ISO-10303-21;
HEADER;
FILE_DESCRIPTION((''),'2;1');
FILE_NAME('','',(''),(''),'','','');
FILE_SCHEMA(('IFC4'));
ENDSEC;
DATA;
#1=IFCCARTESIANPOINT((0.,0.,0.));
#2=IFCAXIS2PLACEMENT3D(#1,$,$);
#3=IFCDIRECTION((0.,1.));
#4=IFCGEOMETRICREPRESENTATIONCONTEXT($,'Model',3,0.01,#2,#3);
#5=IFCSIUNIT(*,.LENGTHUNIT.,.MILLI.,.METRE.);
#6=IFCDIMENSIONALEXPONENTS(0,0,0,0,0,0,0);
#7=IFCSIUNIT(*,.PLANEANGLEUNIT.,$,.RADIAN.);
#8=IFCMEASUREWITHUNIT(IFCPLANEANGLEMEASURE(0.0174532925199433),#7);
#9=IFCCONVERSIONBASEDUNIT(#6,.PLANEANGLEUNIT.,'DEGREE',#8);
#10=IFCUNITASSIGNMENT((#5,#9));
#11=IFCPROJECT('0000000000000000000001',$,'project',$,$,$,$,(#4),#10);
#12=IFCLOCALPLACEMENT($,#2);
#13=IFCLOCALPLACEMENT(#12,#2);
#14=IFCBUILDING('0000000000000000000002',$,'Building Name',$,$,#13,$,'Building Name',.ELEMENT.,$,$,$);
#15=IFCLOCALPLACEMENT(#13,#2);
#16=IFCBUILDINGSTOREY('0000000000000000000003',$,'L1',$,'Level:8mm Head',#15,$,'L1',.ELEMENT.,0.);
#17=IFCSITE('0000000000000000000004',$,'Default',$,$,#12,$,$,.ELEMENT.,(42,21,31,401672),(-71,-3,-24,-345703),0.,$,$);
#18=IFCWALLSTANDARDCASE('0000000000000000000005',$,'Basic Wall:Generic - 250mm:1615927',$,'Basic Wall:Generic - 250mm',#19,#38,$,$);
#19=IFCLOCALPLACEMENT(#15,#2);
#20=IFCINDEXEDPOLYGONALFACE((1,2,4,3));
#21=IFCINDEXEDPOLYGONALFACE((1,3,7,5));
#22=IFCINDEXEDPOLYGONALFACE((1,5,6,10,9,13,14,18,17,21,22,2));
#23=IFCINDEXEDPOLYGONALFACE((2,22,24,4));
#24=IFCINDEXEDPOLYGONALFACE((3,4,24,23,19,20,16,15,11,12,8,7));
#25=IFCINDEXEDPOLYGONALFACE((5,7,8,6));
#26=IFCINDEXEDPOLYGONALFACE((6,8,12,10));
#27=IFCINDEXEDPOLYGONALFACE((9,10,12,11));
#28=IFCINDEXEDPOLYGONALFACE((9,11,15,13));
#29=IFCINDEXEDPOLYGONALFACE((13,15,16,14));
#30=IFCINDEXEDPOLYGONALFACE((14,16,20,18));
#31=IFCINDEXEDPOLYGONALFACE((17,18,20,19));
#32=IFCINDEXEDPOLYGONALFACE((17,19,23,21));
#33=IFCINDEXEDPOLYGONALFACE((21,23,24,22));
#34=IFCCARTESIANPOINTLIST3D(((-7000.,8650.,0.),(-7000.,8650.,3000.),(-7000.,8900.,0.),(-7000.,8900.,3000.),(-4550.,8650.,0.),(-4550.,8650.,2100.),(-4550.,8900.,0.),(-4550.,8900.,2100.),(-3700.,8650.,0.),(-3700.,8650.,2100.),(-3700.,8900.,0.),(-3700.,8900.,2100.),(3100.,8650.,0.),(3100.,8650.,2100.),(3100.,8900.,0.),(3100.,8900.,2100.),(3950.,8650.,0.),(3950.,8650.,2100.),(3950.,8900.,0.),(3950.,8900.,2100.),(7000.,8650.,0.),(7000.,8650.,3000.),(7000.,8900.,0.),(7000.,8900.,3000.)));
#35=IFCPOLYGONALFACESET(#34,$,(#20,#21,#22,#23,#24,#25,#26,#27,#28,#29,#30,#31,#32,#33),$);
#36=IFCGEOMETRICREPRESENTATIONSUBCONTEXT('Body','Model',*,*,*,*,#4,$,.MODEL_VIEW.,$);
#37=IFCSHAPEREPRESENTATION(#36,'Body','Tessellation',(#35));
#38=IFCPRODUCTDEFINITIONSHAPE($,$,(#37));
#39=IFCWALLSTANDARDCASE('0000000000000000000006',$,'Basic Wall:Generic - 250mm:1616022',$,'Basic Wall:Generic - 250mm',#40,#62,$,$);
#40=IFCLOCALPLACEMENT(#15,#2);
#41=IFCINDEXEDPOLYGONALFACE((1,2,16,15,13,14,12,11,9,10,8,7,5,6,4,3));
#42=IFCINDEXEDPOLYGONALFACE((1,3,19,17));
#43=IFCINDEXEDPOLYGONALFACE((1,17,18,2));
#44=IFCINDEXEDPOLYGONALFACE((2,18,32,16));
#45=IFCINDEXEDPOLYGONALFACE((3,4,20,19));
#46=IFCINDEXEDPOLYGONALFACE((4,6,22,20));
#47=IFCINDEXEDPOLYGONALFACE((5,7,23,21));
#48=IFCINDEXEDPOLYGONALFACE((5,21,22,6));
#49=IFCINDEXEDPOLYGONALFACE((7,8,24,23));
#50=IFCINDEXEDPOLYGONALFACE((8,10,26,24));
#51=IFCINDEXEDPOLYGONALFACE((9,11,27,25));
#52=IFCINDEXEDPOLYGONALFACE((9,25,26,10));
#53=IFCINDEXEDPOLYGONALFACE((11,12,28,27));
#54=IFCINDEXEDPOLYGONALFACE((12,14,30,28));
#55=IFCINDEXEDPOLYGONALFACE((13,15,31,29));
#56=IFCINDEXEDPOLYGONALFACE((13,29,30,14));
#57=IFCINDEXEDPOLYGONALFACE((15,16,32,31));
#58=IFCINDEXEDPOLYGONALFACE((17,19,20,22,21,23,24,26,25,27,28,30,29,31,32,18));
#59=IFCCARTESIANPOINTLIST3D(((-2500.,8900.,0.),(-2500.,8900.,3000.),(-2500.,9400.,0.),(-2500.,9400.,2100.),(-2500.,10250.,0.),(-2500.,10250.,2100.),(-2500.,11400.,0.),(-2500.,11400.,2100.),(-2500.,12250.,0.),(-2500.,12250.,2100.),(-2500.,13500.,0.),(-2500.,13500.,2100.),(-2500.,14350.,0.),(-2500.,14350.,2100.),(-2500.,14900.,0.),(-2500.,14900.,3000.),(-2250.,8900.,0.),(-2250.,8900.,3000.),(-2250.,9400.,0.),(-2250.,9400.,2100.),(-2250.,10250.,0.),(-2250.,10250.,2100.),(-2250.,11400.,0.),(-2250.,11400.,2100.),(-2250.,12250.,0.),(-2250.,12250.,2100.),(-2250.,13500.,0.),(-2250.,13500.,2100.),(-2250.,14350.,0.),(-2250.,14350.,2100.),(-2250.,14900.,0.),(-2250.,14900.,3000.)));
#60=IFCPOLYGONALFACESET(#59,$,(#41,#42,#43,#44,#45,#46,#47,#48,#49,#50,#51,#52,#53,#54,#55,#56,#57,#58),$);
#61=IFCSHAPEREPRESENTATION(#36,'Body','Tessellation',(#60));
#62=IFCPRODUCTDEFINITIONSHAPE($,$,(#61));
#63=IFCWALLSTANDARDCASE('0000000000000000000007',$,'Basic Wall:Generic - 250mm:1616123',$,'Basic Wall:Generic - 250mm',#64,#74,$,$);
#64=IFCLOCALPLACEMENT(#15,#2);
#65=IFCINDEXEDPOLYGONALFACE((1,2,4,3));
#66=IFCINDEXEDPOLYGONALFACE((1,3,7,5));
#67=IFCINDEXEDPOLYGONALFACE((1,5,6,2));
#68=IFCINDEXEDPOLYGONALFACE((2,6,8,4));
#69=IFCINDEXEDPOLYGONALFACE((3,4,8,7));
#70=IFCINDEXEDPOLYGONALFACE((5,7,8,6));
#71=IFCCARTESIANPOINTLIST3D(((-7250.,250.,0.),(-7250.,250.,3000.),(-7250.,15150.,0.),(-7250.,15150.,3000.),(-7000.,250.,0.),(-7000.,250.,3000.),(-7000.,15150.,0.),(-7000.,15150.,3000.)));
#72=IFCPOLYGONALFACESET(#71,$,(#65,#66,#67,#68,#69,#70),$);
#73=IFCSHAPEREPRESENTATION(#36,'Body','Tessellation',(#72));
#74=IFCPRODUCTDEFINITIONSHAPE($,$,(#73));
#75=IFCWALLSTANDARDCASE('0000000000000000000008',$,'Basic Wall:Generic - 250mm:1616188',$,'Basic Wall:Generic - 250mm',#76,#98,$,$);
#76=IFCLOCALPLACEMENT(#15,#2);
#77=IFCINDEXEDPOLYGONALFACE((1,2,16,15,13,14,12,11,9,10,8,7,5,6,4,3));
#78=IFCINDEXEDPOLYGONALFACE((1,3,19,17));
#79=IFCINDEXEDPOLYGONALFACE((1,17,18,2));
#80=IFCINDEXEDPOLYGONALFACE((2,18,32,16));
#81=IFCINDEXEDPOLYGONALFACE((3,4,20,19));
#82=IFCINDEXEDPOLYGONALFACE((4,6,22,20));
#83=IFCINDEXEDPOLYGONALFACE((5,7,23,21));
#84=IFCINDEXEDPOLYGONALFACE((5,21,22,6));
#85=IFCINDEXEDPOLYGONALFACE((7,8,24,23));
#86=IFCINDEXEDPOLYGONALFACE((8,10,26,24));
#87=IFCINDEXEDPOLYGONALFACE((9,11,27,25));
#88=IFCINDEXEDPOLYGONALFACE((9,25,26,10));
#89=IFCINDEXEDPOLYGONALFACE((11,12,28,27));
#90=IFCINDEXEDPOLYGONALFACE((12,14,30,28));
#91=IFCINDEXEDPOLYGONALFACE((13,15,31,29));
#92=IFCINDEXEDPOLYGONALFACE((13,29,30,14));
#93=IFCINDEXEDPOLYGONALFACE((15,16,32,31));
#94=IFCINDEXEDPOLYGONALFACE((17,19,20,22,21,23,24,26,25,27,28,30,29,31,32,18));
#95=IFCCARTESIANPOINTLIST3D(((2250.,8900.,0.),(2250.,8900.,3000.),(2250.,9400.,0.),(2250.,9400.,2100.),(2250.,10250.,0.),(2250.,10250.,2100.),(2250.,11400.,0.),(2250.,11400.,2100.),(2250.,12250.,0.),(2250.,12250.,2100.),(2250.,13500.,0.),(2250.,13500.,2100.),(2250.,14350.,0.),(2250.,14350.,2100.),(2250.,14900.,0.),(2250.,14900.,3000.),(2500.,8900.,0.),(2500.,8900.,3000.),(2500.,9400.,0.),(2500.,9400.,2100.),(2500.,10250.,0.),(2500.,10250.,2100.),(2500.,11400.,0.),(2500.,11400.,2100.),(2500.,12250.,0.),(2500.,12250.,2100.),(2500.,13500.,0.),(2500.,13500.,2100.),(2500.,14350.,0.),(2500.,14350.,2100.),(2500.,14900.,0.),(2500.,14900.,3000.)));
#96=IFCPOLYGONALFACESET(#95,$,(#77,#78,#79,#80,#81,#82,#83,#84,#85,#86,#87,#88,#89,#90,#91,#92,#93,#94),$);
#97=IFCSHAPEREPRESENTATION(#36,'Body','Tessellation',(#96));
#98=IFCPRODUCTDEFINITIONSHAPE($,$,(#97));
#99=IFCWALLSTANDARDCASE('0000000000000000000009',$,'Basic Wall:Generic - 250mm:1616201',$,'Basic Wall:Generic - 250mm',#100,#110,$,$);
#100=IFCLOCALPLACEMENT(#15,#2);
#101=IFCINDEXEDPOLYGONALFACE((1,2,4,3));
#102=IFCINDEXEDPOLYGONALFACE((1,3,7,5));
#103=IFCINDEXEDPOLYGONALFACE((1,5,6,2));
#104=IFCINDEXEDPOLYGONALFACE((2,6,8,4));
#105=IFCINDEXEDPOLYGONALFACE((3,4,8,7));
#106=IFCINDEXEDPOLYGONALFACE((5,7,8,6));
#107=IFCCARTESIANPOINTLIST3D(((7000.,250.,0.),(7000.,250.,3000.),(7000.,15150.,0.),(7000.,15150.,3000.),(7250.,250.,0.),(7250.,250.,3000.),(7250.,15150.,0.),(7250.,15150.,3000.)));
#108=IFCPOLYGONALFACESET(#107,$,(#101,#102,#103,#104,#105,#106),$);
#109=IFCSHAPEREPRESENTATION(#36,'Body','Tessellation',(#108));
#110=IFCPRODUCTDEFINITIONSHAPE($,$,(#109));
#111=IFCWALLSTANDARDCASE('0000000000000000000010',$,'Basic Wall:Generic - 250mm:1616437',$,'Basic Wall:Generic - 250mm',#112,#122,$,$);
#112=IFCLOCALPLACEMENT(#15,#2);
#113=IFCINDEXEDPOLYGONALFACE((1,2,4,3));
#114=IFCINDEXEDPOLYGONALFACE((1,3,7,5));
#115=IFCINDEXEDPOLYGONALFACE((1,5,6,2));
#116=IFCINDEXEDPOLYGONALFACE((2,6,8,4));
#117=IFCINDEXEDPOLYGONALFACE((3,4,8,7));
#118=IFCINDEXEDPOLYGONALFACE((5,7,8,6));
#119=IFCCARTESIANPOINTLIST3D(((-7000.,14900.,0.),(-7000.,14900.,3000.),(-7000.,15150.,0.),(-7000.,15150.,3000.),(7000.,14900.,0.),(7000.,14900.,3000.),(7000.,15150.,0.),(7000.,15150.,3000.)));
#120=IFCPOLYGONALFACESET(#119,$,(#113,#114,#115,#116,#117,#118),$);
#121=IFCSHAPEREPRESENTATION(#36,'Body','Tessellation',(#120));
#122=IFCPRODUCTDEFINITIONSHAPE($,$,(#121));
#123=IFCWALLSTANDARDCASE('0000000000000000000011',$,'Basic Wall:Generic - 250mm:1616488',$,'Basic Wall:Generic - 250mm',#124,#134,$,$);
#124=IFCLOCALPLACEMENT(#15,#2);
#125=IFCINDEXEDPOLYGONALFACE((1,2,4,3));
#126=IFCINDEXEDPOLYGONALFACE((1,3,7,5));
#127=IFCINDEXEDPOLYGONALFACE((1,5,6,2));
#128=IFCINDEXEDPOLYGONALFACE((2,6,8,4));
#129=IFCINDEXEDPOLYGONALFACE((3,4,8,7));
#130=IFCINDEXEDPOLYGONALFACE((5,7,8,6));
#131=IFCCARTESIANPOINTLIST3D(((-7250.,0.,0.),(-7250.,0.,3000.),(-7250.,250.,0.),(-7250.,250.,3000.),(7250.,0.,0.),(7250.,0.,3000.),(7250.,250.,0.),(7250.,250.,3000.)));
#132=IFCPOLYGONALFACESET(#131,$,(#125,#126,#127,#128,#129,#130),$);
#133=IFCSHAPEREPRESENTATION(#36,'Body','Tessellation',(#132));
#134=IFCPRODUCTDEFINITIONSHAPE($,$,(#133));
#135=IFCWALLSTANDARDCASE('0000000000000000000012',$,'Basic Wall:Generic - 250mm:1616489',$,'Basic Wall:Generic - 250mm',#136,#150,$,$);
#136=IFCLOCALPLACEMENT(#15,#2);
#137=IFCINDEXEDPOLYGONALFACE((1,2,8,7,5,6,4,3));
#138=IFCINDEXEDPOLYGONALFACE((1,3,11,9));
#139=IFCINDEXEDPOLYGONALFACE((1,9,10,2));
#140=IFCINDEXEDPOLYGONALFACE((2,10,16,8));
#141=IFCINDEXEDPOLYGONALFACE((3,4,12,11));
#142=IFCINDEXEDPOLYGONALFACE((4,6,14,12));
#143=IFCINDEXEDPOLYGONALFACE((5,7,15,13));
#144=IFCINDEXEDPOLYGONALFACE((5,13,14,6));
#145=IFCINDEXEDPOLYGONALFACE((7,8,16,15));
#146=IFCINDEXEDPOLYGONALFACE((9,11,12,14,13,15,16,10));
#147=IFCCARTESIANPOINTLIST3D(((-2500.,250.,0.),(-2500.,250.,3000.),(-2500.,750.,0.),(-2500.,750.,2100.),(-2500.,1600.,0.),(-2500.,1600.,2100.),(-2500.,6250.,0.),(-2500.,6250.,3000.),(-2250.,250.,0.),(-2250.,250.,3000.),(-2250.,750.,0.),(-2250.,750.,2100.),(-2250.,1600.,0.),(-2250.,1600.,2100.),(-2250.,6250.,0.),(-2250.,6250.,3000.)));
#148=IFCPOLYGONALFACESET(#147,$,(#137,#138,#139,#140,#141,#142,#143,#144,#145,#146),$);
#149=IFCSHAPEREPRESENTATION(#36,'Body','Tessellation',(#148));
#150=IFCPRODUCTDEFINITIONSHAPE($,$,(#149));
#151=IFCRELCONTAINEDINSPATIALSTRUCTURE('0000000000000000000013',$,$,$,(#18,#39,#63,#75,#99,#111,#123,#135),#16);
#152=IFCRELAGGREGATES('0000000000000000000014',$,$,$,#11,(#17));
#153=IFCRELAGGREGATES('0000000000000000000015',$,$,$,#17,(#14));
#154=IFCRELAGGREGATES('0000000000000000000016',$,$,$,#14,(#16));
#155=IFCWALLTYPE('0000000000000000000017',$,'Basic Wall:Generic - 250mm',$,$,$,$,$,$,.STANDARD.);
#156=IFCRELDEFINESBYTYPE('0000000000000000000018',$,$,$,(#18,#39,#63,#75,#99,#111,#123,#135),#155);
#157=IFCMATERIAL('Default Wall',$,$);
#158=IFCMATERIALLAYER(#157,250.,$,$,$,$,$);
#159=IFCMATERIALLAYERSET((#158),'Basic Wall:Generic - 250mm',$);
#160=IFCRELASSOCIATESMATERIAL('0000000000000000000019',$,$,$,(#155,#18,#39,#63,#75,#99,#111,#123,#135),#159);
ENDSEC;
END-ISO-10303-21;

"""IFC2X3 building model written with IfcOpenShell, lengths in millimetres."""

from ifc_helpers import new_model, entity, si_unit, converted_unit, direction, frame, frame_2d, origin, place, context, subcontext, project, spatial, rectangle, extrude, material, layer, layer_set, layer_usage, type_object, element, save


model = new_model("IFC2X3")

# Units and contexts
model_context = context("Model", 3, precision=0.01, world=origin(), true_north=direction((0.0, 1.0)))
body_context = subcontext(model_context, "Body", "Model", "MODEL_VIEW")
ifc_project = project(units=[si_unit("LENGTHUNIT", "METRE", prefix="MILLI"), converted_unit("PLANEANGLEUNIT", "DEGREE", entity("IfcPlaneAngleMeasure", 0.0174532925199433), si_unit("PLANEANGLEUNIT", "RADIAN"), dimensions=[0, 0, 0, 0, 0, 0, 0])], contexts=[model_context])

# Site, building, storey
site_placement = place(None, origin())
site = spatial("IfcSite", under=ifc_project, at=site_placement, Name="Default", CompositionType="ELEMENT", RefLatitude=(42, 21, 31, 401672), RefLongitude=(-71, -3, -24, -345703), RefElevation=0.0)
building_placement = place(site_placement, origin())
building = spatial("IfcBuilding", under=site, at=building_placement, Name="Building Name", LongName="Building Name", CompositionType="ELEMENT")
storey_placement = place(building_placement, origin())
storey = spatial("IfcBuildingStorey", under=building, at=storey_placement, Name="L1", ObjectType="Level:8mm Head", LongName="L1", CompositionType="ELEMENT", Elevation=0.0)

# Walls, openings
ifc_material = material(Name="Default Wall")
ifc_layer_1 = layer(ifc_material, 250.0)
ifc_layer_set_1 = layer_set([ifc_layer_1], Name="Basic Wall:Generic - 250mm")
ifc_layer_usage_1 = layer_usage(ifc_layer_set_1, "AXIS2", "NEGATIVE", 125.0)
wall_type_1 = type_object("IfcWallType", Name="Basic Wall:Generic - 250mm", PredefinedType="STANDARD", material=ifc_layer_set_1)
wall_1_placement = place(storey_placement, frame((-7000.0, 8775.0, 0.0)))
wall_1 = element("IfcWallStandardCase", 1, at=wall_1_placement, inside=storey, type_object=wall_type_1, material=ifc_layer_usage_1, Name="Basic Wall:Generic - 250mm:1615927", ObjectType="Basic Wall:Generic - 250mm", context=body_context, shape_type="SweptSolid", body=[
    extrude(rectangle(XDim=14000.0, YDim=250.0, at=frame_2d((7000.0, 0.0), x_axis=(1.0, 0.0))), origin(), (0.0, 0.0, 1.0), 3000.0),
])
opening_1_placement = place(wall_1_placement, frame((2450.0, -125.0, 0.0)))
element("IfcOpeningElement", 2, at=opening_1_placement, cuts=wall_1, ObjectType="Opening", context=body_context, shape_type="SweptSolid", body=[
    extrude(rectangle(XDim=2100.0, YDim=850.0, at=frame_2d((1050.0, 425.0), x_axis=(1.0, 0.0))), frame((0.0, 0.0, 0.0), z_axis=(0.0, 1.0, 0.0), x_axis=(0.0, 0.0, 1.0)), (0.0, 0.0, 1.0), 250.0),
])
opening_2_placement = place(wall_1_placement, frame((10100.0, -125.0, 0.0)))
element("IfcOpeningElement", 3, at=opening_2_placement, cuts=wall_1, ObjectType="Opening", context=body_context, shape_type="SweptSolid", body=[
    extrude(rectangle(XDim=2100.0, YDim=850.0, at=frame_2d((1050.0, 425.0), x_axis=(1.0, 0.0))), frame((0.0, 0.0, 0.0), z_axis=(0.0, 1.0, 0.0), x_axis=(0.0, 0.0, 1.0)), (0.0, 0.0, 1.0), 250.0),
])
ifc_layer_usage_2 = layer_usage(ifc_layer_set_1, "AXIS2", "NEGATIVE", 125.0)
wall_2_placement = place(storey_placement, frame((-2375.0, 8900.0, 0.0), z_axis=(0.0, 0.0, 1.0), x_axis=(0.0, 1.0, 0.0)))
wall_2 = element("IfcWallStandardCase", 4, at=wall_2_placement, inside=storey, type_object=wall_type_1, material=ifc_layer_usage_2, Name="Basic Wall:Generic - 250mm:1616022", ObjectType="Basic Wall:Generic - 250mm", context=body_context, shape_type="SweptSolid", body=[
    extrude(rectangle(XDim=6000.0, YDim=250.0, at=frame_2d((3000.0, 0.0), x_axis=(1.0, 0.0))), origin(), (0.0, 0.0, 1.0), 3000.0),
])
opening_3_placement = place(wall_2_placement, frame((1350.0, 125.0, 0.0)))
element("IfcOpeningElement", 5, at=opening_3_placement, cuts=wall_2, ObjectType="Opening", context=body_context, shape_type="SweptSolid", body=[
    extrude(rectangle(XDim=2100.0, YDim=850.0, at=frame_2d((1050.0, 425.0), x_axis=(1.0, 0.0))), frame((0.0, 0.0, 0.0), z_axis=(0.0, -1.0, 0.0), x_axis=(0.0, 0.0, 1.0)), (0.0, 0.0, 1.0), 250.0),
])
opening_4_placement = place(wall_2_placement, frame((3350.0, 125.0, 0.0)))
element("IfcOpeningElement", 6, at=opening_4_placement, cuts=wall_2, ObjectType="Opening", context=body_context, shape_type="SweptSolid", body=[
    extrude(rectangle(XDim=2100.0, YDim=850.0, at=frame_2d((1050.0, 425.0), x_axis=(1.0, 0.0))), frame((0.0, 0.0, 0.0), z_axis=(0.0, -1.0, 0.0), x_axis=(0.0, 0.0, 1.0)), (0.0, 0.0, 1.0), 250.0),
])
opening_5_placement = place(wall_2_placement, frame((5450.0, 125.0, 0.0)))
element("IfcOpeningElement", 7, at=opening_5_placement, cuts=wall_2, ObjectType="Opening", context=body_context, shape_type="SweptSolid", body=[
    extrude(rectangle(XDim=2100.0, YDim=850.0, at=frame_2d((1050.0, 425.0), x_axis=(1.0, 0.0))), frame((0.0, 0.0, 0.0), z_axis=(0.0, -1.0, 0.0), x_axis=(0.0, 0.0, 1.0)), (0.0, 0.0, 1.0), 250.0),
])

# Wall
ifc_layer_usage_3 = layer_usage(ifc_layer_set_1, "AXIS2", "NEGATIVE", 125.0)
wall_3_placement = place(storey_placement, frame((-7125.0, 15150.0, 0.0), z_axis=(0.0, 0.0, 1.0), x_axis=(0.0, -1.0, 0.0)))
element("IfcWallStandardCase", 8, at=wall_3_placement, inside=storey, type_object=wall_type_1, material=ifc_layer_usage_3, Name="Basic Wall:Generic - 250mm:1616123", ObjectType="Basic Wall:Generic - 250mm", context=body_context, shape_type="SweptSolid", body=[
    extrude(rectangle(XDim=14900.0, YDim=250.0, at=frame_2d((7450.0, 0.0), x_axis=(-1.0, 0.0))), origin(), (0.0, 0.0, 1.0), 3000.0),
])

# Wall, openings
ifc_layer_usage_4 = layer_usage(ifc_layer_set_1, "AXIS2", "NEGATIVE", 125.0)
wall_4_placement = place(storey_placement, frame((2375.0, 8900.0, 0.0), z_axis=(0.0, 0.0, 1.0), x_axis=(0.0, 1.0, 0.0)))
wall_4 = element("IfcWallStandardCase", 9, at=wall_4_placement, inside=storey, type_object=wall_type_1, material=ifc_layer_usage_4, Name="Basic Wall:Generic - 250mm:1616188", ObjectType="Basic Wall:Generic - 250mm", context=body_context, shape_type="SweptSolid", body=[
    extrude(rectangle(XDim=6000.0, YDim=250.0, at=frame_2d((3000.0, 0.0), x_axis=(-1.0, 0.0))), origin(), (0.0, 0.0, 1.0), 3000.0),
])
opening_6_placement = place(wall_4_placement, frame((500.0, -125.0, 0.0)))
element("IfcOpeningElement", 10, at=opening_6_placement, cuts=wall_4, ObjectType="Opening", context=body_context, shape_type="SweptSolid", body=[
    extrude(rectangle(XDim=2100.0, YDim=850.0, at=frame_2d((1050.0, 425.0), x_axis=(1.0, 0.0))), frame((0.0, 0.0, 0.0), z_axis=(0.0, 1.0, 0.0), x_axis=(0.0, 0.0, 1.0)), (0.0, 0.0, 1.0), 250.0),
])
opening_7_placement = place(wall_4_placement, frame((2500.0, -125.0, 0.0)))
element("IfcOpeningElement", 11, at=opening_7_placement, cuts=wall_4, ObjectType="Opening", context=body_context, shape_type="SweptSolid", body=[
    extrude(rectangle(XDim=2100.0, YDim=850.0, at=frame_2d((1050.0, 425.0), x_axis=(1.0, 0.0))), frame((0.0, 0.0, 0.0), z_axis=(0.0, 1.0, 0.0), x_axis=(0.0, 0.0, 1.0)), (0.0, 0.0, 1.0), 250.0),
])
opening_8_placement = place(wall_4_placement, frame((4600.0, -125.0, 0.0)))
element("IfcOpeningElement", 12, at=opening_8_placement, cuts=wall_4, ObjectType="Opening", context=body_context, shape_type="SweptSolid", body=[
    extrude(rectangle(XDim=2100.0, YDim=850.0, at=frame_2d((1050.0, 425.0), x_axis=(1.0, 0.0))), frame((0.0, 0.0, 0.0), z_axis=(0.0, 1.0, 0.0), x_axis=(0.0, 0.0, 1.0)), (0.0, 0.0, 1.0), 250.0),
])

# Walls
ifc_layer_usage_5 = layer_usage(ifc_layer_set_1, "AXIS2", "NEGATIVE", 125.0)
wall_5_placement = place(storey_placement, frame((7125.0, 250.0, 0.0), z_axis=(0.0, 0.0, 1.0), x_axis=(0.0, 1.0, 0.0)))
element("IfcWallStandardCase", 13, at=wall_5_placement, inside=storey, type_object=wall_type_1, material=ifc_layer_usage_5, Name="Basic Wall:Generic - 250mm:1616201", ObjectType="Basic Wall:Generic - 250mm", context=body_context, shape_type="SweptSolid", body=[
    extrude(rectangle(XDim=14900.0, YDim=250.0, at=frame_2d((7450.0, 0.0), x_axis=(-1.0, 0.0))), origin(), (0.0, 0.0, 1.0), 3000.0),
])
ifc_layer_usage_6 = layer_usage(ifc_layer_set_1, "AXIS2", "NEGATIVE", 125.0)
wall_6_placement = place(storey_placement, frame((-7000.0, 15025.0, 0.0)))
element("IfcWallStandardCase", 14, at=wall_6_placement, inside=storey, type_object=wall_type_1, material=ifc_layer_usage_6, Name="Basic Wall:Generic - 250mm:1616437", ObjectType="Basic Wall:Generic - 250mm", context=body_context, shape_type="SweptSolid", body=[
    extrude(rectangle(XDim=14000.0, YDim=250.0, at=frame_2d((7000.0, 0.0), x_axis=(-1.0, 0.0))), origin(), (0.0, 0.0, 1.0), 3000.0),
])
ifc_layer_usage_7 = layer_usage(ifc_layer_set_1, "AXIS2", "NEGATIVE", 125.0)
wall_7_placement = place(storey_placement, frame((-7250.0, 125.0, 0.0)))
element("IfcWallStandardCase", 15, at=wall_7_placement, inside=storey, type_object=wall_type_1, material=ifc_layer_usage_7, Name="Basic Wall:Generic - 250mm:1616488", ObjectType="Basic Wall:Generic - 250mm", context=body_context, shape_type="SweptSolid", body=[
    extrude(rectangle(XDim=14500.0, YDim=250.0, at=frame_2d((7250.0, 0.0), x_axis=(-1.0, 0.0))), origin(), (0.0, 0.0, 1.0), 3000.0),
])

# Wall, opening
ifc_layer_usage_8 = layer_usage(ifc_layer_set_1, "AXIS2", "NEGATIVE", 125.0)
wall_8_placement = place(storey_placement, frame((-2375.0, 250.0, 0.0), z_axis=(0.0, 0.0, 1.0), x_axis=(0.0, 1.0, 0.0)))
wall_8 = element("IfcWallStandardCase", 16, at=wall_8_placement, inside=storey, type_object=wall_type_1, material=ifc_layer_usage_8, Name="Basic Wall:Generic - 250mm:1616489", ObjectType="Basic Wall:Generic - 250mm", context=body_context, shape_type="SweptSolid", body=[
    extrude(rectangle(XDim=6000.0, YDim=250.0, at=frame_2d((3000.0, 0.0), x_axis=(1.0, 0.0))), origin(), (0.0, 0.0, 1.0), 3000.0),
])
opening_9_placement = place(wall_8_placement, frame((1350.0, 125.0, 0.0)))
element("IfcOpeningElement", 17, at=opening_9_placement, cuts=wall_8, ObjectType="Opening", context=body_context, shape_type="SweptSolid", body=[
    extrude(rectangle(XDim=2100.0, YDim=850.0, at=frame_2d((1050.0, 425.0), x_axis=(1.0, 0.0))), frame((0.0, 0.0, 0.0), z_axis=(0.0, -1.0, 0.0), x_axis=(0.0, 0.0, 1.0)), (0.0, 0.0, 1.0), 250.0),
])

save(model, "model.ifc")
